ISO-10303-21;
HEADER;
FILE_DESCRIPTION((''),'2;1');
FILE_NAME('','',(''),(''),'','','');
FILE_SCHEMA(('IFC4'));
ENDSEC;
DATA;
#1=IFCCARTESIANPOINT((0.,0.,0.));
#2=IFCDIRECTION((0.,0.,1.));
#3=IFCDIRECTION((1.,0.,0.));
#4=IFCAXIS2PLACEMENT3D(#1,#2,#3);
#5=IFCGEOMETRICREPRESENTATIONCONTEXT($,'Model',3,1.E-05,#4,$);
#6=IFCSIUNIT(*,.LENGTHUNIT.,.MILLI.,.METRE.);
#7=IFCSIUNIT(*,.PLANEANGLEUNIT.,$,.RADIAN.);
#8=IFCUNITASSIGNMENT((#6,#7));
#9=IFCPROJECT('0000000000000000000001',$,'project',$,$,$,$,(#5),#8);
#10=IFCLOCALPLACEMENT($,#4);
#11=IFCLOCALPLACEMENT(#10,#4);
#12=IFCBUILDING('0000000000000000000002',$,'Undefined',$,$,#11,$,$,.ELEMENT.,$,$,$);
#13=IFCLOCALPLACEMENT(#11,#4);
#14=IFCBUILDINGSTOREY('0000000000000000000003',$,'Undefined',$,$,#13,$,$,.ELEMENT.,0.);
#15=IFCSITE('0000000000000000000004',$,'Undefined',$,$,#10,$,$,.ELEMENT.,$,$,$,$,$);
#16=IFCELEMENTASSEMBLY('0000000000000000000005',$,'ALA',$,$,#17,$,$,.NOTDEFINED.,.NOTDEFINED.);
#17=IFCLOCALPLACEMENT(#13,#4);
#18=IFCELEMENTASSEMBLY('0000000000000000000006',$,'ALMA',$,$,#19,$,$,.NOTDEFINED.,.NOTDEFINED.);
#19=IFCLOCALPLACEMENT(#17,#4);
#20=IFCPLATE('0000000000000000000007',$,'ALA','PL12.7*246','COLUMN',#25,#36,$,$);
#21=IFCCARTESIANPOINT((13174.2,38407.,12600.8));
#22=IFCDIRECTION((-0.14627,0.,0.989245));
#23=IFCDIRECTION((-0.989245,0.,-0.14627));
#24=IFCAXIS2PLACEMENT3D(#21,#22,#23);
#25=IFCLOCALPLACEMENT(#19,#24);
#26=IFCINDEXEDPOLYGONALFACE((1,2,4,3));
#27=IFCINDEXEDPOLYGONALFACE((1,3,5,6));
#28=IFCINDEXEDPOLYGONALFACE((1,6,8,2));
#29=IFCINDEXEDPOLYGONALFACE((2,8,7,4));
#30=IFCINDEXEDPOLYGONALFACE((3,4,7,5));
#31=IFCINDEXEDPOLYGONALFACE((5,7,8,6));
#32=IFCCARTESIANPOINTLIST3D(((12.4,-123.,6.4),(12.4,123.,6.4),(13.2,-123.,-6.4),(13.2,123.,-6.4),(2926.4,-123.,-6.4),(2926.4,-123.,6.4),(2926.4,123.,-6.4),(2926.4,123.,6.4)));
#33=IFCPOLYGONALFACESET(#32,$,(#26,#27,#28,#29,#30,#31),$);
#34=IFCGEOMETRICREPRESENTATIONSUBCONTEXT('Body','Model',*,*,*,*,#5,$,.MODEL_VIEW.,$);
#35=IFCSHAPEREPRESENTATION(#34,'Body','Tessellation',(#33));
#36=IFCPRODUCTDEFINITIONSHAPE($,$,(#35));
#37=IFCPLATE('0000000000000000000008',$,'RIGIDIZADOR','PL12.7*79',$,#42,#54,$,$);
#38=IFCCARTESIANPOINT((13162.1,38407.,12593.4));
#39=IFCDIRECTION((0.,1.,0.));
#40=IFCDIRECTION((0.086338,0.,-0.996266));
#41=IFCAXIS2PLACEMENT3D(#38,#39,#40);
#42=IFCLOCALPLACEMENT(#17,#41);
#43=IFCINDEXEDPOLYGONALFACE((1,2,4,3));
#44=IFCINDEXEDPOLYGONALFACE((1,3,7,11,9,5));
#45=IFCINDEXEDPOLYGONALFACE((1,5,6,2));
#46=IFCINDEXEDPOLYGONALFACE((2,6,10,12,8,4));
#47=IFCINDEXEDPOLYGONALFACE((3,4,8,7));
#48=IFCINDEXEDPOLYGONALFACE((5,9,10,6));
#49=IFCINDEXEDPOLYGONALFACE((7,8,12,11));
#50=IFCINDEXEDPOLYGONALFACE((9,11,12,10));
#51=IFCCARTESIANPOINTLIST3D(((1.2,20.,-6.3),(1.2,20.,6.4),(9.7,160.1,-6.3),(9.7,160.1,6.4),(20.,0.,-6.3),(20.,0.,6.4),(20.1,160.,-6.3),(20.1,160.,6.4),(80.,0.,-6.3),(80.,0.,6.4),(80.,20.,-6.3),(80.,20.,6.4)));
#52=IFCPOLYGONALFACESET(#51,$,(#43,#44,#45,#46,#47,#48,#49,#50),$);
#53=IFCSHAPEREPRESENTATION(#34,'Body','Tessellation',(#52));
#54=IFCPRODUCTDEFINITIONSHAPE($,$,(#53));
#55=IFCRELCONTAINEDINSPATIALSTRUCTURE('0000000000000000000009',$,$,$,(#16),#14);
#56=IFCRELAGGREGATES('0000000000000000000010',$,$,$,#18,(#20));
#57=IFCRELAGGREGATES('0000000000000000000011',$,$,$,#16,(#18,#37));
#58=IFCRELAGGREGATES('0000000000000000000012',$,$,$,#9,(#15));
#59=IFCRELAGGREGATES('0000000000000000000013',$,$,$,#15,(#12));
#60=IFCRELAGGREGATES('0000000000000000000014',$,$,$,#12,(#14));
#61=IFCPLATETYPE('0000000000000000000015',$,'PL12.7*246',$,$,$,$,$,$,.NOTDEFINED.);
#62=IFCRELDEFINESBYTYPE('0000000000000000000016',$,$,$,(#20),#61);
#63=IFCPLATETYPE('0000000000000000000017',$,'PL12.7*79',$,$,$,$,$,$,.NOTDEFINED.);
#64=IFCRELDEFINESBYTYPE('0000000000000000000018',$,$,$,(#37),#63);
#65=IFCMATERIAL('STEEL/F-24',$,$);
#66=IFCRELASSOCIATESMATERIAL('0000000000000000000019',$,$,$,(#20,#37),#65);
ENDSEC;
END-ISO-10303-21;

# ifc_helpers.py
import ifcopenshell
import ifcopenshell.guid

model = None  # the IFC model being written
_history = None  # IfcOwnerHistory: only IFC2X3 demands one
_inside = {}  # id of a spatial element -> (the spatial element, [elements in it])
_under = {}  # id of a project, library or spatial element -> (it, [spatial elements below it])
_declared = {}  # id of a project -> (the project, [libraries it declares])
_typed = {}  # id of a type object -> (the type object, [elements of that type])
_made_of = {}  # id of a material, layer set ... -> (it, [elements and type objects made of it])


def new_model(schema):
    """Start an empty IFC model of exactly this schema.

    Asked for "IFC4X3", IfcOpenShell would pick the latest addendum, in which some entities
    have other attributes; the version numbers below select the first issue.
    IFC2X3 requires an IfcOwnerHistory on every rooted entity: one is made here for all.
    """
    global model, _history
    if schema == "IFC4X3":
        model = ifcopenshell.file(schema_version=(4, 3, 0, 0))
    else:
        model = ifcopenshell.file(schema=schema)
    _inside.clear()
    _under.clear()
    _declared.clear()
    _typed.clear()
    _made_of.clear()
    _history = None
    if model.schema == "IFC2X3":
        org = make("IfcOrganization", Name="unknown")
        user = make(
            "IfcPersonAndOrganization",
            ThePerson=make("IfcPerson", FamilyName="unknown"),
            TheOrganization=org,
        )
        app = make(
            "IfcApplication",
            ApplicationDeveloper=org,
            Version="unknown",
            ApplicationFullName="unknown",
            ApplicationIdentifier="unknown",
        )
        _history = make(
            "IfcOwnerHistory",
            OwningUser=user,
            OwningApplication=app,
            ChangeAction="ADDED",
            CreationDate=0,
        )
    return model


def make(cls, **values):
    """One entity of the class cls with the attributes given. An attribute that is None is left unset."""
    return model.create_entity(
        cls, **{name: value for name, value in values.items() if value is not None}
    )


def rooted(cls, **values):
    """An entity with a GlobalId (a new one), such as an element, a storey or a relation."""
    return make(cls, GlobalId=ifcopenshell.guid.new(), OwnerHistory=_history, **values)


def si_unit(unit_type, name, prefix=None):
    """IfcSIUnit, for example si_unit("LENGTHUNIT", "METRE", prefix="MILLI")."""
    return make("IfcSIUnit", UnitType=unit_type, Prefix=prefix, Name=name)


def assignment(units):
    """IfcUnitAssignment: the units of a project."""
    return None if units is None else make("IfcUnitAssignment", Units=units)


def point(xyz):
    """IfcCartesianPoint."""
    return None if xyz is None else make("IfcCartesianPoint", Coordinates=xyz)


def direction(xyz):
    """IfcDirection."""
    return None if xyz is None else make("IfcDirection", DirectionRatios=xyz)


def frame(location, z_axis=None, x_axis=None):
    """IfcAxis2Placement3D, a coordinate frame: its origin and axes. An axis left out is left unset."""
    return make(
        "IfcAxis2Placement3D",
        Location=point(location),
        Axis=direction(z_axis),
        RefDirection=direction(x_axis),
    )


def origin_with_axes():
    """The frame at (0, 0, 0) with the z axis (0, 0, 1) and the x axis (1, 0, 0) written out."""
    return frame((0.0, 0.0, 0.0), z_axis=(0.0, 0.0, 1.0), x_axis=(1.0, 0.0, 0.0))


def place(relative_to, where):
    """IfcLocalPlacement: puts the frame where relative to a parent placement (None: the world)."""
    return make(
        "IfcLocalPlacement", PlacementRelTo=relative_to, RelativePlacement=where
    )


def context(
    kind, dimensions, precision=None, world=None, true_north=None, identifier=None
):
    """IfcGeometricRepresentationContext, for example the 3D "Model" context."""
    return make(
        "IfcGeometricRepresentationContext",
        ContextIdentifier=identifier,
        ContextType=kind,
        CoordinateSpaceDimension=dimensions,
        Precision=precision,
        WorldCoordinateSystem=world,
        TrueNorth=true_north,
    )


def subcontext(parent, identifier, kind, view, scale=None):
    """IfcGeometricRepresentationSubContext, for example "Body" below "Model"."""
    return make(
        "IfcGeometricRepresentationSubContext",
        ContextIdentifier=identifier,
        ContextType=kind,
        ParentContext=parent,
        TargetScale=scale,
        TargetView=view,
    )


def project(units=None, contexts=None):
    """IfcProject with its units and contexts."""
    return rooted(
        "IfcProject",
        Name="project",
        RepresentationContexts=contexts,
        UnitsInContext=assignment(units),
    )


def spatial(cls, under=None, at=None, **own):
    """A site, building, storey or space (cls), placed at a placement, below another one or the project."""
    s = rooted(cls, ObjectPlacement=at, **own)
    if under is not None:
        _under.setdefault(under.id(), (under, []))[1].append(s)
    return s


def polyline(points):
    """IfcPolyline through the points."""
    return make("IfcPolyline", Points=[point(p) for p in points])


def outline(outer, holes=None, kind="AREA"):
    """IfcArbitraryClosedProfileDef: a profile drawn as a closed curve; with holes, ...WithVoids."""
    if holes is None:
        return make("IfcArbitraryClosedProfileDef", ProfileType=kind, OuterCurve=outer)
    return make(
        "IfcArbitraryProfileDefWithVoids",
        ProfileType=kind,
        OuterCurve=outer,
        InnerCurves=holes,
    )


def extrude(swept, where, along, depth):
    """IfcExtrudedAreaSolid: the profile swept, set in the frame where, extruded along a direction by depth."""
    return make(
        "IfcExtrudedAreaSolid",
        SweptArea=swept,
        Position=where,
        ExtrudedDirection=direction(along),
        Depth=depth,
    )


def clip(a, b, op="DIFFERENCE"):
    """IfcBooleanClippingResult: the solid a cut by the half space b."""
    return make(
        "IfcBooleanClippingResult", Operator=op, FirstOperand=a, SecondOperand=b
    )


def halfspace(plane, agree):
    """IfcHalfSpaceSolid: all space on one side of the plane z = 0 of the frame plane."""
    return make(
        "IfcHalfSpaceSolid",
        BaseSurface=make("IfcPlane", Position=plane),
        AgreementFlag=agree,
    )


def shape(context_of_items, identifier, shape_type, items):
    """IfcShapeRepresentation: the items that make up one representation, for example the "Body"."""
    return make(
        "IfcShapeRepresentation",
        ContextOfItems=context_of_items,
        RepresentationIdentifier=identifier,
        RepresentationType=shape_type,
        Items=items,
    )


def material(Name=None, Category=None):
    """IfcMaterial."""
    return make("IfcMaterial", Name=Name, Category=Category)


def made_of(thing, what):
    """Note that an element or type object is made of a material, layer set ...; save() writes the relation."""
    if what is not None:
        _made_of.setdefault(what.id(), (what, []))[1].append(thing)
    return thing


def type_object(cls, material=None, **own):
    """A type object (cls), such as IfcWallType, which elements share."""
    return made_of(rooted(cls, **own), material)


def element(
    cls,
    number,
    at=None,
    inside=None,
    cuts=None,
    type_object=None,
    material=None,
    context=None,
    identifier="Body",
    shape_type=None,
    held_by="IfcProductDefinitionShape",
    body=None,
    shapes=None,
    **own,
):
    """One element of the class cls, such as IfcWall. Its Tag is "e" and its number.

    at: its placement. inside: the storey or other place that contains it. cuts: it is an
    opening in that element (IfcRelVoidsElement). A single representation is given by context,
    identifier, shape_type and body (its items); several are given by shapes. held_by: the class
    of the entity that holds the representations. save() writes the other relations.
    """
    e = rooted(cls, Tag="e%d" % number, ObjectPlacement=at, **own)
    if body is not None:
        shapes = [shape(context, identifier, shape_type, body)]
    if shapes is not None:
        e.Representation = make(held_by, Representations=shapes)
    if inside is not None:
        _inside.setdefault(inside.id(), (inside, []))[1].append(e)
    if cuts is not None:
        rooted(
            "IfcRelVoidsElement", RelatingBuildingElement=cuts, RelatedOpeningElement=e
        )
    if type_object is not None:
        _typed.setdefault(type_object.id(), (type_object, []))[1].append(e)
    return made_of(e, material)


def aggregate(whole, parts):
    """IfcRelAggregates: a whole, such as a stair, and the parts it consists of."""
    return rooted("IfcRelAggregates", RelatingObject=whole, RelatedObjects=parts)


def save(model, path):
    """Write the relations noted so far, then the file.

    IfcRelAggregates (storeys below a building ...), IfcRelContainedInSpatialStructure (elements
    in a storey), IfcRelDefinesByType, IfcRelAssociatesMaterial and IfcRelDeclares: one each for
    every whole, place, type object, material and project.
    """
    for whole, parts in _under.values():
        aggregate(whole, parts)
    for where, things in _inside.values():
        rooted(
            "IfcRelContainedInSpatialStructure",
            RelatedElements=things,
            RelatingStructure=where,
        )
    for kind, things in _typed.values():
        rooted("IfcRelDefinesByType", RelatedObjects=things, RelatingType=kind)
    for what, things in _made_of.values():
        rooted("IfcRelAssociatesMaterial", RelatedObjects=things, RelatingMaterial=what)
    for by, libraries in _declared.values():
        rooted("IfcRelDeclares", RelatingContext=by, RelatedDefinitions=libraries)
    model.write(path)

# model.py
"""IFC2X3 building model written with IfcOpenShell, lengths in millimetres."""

from ifc_helpers import new_model, si_unit, frame, origin_with_axes, place, context, subcontext, project, spatial, polyline, outline, extrude, clip, halfspace, material, type_object, element, aggregate, save


model = new_model("IFC2X3")

# Units and contexts
model_context = context("Model", 3, precision=1e-05, world=origin_with_axes())
body_context = subcontext(model_context, "Body", "Model", "MODEL_VIEW")
ifc_project = project(units=[si_unit("LENGTHUNIT", "METRE", prefix="MILLI"), si_unit("PLANEANGLEUNIT", "RADIAN")], contexts=[model_context])

# Site, building, storey
site_placement = place(None, origin_with_axes())
site = spatial("IfcSite", under=ifc_project, at=site_placement, Name="Undefined", CompositionType="ELEMENT")
building_placement = place(site_placement, origin_with_axes())
building = spatial("IfcBuilding", under=site, at=building_placement, Name="Undefined", CompositionType="ELEMENT")
storey_placement = place(building_placement, origin_with_axes())
storey = spatial("IfcBuildingStorey", under=building, at=storey_placement, Name="Undefined", CompositionType="ELEMENT", Elevation=0.0)

# Shared definitions
ifc_material_1 = material(Name="STEEL/F-24")

# Element assembly
assembly_1_placement = place(storey_placement, origin_with_axes())
assembly_1 = element("IfcElementAssembly", 1, at=assembly_1_placement, inside=storey, Name="ALA", AssemblyPlace="NOTDEFINED", PredefinedType="NOTDEFINED")

# Shared definitions
plate_type_1 = type_object("IfcPlateType", Name="PL12.7*246", PredefinedType="NOTDEFINED")

# Element assembly, plate
assembly_2_placement = place(assembly_1_placement, origin_with_axes())
assembly_2 = element("IfcElementAssembly", 2, at=assembly_2_placement, Name="ALMA", AssemblyPlace="NOTDEFINED", PredefinedType="NOTDEFINED")
plate_1_placement = place(assembly_2_placement, frame((13174.2, 38407.0, 12600.8), z_axis=(-0.14627, 0.0, 0.989245), x_axis=(-0.989245, 0.0, -0.14627)))
plate_1 = element("IfcPlate", 3, at=plate_1_placement, type_object=plate_type_1, material=ifc_material_1, Name="ALA", Description="PL12.7*246", ObjectType="COLUMN", context=body_context, shape_type="Clipping", body=[
    clip(extrude(outline(polyline([(12.4, -123.0), (12.4, 123.0), (2926.4, 123.0), (2926.4, -123.0), (12.4, -123.0)])), frame((0.0, 0.0, -6.3), z_axis=(0.0, 0.0, 1.0), x_axis=(1.0, 0.0, 0.0)), (0.0, 0.0, 1.0), 12.7), halfspace(frame((12.8, 0.0, 0.0), z_axis=(0.998229, 0.0, 0.059495), x_axis=(0.0, 1.0, 0.0)), True)),
])
aggregate(assembly_2, [plate_1])

# Plate
plate_type_2 = type_object("IfcPlateType", Name="PL12.7*79", PredefinedType="NOTDEFINED")
plate_2_placement = place(assembly_1_placement, frame((13162.1, 38407.0, 12593.4), z_axis=(0.0, 1.0, 0.0), x_axis=(0.086338, 0.0, -0.996266)))
plate_2 = element("IfcPlate", 4, at=plate_2_placement, type_object=plate_type_2, material=ifc_material_1, Name="RIGIDIZADOR", Description="PL12.7*79", context=body_context, shape_type="SweptSolid", body=[
    extrude(outline(polyline([(1.2, 20.0), (20.0, 0.0), (80.0, 0.0), (80.0, 20.0), (20.1, 160.0), (9.7, 160.1), (1.2, 20.0)])), frame((0.0, 0.0, -6.3), z_axis=(0.0, 0.0, 1.0), x_axis=(1.0, 0.0, 0.0)), (0.0, 0.0, 1.0), 12.7),
])

aggregate(assembly_1, [assembly_2, plate_2])

save(model, "model.ifc")
